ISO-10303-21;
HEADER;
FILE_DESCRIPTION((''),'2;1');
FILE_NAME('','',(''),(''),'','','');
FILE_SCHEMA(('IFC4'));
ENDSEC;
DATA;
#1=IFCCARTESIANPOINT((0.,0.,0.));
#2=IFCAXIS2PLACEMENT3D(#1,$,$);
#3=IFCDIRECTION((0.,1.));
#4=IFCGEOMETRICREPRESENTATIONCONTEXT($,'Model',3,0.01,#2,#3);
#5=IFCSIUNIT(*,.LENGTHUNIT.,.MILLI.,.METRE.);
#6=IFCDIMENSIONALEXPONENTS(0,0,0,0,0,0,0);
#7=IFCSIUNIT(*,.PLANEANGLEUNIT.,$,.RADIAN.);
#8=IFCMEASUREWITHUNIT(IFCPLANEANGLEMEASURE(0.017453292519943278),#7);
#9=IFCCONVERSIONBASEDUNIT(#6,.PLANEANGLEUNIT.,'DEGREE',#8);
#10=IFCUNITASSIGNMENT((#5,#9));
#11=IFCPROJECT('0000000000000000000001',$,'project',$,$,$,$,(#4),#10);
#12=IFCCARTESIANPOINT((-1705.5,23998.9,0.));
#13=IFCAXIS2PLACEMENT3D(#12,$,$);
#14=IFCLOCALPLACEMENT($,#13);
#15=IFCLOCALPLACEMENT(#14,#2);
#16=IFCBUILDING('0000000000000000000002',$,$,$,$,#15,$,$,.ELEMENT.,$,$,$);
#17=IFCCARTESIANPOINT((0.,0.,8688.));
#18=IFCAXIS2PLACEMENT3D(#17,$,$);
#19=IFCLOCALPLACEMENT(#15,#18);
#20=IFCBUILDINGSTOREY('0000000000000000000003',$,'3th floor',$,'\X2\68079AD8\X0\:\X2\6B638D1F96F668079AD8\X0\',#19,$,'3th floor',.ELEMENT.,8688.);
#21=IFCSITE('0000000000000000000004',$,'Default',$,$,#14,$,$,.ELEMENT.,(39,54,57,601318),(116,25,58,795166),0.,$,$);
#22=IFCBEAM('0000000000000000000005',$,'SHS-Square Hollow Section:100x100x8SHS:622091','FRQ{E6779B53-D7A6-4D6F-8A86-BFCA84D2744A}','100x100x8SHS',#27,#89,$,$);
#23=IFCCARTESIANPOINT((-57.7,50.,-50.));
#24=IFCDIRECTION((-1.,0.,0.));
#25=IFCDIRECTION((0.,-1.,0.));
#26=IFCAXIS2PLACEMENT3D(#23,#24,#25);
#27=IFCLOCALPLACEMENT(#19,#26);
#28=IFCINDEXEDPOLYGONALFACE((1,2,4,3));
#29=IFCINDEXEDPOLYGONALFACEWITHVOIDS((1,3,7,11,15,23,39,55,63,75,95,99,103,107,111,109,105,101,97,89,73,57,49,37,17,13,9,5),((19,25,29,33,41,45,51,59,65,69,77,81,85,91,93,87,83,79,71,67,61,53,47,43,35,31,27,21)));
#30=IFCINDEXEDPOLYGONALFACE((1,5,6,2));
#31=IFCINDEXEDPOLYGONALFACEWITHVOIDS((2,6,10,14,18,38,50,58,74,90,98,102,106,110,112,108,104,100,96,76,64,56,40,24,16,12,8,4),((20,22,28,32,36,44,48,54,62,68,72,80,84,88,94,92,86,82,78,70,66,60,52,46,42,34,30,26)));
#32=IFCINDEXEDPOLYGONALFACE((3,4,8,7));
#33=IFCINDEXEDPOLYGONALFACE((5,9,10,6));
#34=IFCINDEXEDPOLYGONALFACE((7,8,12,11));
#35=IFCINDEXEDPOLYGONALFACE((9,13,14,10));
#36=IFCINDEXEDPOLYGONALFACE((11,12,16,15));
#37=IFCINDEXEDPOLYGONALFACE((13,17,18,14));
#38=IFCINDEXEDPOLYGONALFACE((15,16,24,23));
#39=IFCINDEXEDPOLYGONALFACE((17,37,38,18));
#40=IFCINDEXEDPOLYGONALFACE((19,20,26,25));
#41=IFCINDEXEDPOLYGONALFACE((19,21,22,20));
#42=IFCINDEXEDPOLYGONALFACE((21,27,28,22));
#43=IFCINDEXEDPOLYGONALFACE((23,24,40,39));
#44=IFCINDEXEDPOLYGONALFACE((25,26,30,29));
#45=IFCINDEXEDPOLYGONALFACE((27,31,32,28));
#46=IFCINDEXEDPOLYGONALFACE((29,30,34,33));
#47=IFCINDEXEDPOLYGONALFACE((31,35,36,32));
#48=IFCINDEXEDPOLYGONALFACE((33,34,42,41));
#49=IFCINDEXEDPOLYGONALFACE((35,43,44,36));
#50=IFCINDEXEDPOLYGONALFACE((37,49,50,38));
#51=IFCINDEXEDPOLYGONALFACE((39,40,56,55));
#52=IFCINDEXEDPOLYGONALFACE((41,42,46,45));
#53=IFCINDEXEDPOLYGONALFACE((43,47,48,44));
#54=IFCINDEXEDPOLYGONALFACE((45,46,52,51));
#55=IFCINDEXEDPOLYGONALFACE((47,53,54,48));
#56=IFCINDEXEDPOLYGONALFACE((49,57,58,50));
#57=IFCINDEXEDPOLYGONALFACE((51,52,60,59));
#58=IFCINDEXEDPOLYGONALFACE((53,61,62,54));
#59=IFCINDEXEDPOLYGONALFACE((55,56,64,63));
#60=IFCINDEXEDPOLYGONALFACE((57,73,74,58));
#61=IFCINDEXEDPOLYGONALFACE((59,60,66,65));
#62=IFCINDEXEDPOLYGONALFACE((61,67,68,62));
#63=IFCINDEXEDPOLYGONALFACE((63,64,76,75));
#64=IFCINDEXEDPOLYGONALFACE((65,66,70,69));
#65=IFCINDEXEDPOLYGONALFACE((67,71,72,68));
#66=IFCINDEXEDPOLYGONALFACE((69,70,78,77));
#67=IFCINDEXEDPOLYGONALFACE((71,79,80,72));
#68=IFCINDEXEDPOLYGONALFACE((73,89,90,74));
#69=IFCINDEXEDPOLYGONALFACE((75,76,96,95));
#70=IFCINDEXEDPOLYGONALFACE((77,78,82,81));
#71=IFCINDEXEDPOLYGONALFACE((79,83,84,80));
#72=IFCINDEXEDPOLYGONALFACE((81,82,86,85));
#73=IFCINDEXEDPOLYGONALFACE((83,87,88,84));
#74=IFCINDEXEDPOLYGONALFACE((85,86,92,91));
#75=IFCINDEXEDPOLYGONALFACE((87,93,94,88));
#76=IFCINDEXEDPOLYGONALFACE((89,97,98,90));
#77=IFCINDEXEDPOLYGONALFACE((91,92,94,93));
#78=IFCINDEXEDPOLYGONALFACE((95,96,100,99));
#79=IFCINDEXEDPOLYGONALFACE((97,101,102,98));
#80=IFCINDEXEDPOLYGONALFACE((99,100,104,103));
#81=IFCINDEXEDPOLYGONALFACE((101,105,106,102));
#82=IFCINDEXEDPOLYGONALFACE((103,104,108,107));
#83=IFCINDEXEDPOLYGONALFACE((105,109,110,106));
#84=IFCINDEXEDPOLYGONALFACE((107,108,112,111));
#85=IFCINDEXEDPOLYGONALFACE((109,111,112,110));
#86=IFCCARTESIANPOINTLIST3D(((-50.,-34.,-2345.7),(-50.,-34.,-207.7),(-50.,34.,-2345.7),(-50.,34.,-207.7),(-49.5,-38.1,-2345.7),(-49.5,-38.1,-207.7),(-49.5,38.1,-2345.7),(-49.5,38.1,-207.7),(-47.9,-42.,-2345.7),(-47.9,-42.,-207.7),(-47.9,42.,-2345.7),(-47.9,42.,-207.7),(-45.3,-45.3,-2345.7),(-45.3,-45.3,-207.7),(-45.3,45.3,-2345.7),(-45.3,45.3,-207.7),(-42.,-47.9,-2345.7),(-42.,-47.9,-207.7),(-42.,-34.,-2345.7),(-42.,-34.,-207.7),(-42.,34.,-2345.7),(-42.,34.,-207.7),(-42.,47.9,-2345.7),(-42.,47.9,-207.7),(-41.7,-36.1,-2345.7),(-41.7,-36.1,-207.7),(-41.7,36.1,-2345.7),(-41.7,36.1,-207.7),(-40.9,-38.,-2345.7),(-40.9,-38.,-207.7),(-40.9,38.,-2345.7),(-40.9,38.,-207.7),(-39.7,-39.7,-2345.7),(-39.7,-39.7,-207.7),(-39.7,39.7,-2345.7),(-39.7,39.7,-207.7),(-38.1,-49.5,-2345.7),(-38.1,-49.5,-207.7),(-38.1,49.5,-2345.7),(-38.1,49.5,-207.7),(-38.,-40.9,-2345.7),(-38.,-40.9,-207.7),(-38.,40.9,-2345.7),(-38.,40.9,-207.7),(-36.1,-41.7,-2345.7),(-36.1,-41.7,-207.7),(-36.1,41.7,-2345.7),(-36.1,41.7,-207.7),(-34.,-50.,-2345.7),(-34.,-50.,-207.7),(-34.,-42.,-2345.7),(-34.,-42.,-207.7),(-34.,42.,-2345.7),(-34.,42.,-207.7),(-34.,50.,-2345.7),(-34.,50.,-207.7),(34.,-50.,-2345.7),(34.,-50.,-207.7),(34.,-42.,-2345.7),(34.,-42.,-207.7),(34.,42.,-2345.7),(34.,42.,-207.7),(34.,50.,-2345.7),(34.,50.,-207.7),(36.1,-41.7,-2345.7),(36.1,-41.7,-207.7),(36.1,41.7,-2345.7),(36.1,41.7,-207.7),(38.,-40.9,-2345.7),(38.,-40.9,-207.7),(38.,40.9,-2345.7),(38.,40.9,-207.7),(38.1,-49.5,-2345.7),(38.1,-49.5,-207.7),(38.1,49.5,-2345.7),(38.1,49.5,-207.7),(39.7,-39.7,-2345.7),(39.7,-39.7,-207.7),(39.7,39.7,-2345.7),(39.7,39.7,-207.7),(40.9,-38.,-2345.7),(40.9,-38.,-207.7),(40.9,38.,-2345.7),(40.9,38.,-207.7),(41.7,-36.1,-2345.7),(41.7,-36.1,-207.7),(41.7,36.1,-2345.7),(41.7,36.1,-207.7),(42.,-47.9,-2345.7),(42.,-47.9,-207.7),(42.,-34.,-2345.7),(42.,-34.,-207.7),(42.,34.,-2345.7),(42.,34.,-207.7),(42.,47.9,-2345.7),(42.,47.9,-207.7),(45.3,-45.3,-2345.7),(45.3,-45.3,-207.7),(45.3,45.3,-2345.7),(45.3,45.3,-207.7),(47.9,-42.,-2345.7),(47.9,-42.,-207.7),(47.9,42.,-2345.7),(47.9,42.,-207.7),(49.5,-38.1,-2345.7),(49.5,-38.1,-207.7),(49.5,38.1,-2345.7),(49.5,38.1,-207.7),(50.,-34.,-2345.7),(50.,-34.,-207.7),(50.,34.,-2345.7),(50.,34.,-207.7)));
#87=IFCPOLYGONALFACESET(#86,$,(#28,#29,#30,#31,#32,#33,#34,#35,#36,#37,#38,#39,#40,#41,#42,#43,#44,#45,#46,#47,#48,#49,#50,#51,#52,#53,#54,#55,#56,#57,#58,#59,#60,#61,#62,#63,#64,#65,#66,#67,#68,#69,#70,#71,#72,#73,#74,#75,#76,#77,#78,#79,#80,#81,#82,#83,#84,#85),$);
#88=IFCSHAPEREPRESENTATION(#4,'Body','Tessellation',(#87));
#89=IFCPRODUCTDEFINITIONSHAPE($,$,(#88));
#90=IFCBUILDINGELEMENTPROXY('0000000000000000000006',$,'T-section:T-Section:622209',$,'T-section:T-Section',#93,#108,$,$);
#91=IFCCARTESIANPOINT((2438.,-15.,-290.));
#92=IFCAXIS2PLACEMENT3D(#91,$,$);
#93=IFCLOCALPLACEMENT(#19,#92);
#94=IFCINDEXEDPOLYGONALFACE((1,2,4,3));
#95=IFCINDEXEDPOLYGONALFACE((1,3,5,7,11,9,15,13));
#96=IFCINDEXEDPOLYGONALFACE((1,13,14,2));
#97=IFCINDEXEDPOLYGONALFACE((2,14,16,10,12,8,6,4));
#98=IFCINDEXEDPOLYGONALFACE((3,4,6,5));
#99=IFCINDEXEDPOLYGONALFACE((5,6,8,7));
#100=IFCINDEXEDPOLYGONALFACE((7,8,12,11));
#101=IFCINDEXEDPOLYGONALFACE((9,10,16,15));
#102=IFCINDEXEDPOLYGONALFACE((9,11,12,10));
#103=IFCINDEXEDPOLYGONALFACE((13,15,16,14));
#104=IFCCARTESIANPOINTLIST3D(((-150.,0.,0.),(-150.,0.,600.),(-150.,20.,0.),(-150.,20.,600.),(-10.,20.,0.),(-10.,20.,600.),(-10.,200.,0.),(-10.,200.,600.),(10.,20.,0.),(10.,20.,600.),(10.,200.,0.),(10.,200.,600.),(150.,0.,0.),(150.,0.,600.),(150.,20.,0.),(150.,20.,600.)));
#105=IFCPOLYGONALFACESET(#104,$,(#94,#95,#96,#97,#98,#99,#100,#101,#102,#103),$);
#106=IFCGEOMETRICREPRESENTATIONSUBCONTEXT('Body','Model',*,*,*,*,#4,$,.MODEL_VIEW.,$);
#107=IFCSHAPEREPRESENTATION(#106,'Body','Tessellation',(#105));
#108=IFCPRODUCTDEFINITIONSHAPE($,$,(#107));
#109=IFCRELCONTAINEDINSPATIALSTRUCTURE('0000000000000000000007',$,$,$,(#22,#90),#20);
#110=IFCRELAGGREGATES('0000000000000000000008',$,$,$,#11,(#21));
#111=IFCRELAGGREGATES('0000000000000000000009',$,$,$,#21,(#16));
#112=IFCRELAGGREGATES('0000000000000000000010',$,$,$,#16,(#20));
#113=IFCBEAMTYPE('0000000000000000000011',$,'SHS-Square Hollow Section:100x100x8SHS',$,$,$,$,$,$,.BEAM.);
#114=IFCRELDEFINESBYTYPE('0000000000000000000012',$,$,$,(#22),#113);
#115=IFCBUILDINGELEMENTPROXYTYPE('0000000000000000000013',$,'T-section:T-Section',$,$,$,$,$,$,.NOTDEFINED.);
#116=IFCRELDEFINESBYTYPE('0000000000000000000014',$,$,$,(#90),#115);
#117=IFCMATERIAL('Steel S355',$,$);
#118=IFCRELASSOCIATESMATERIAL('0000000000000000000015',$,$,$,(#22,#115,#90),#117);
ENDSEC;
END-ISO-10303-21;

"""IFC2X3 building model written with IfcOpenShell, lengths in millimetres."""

from ifc_helpers import new_model, entity, si_unit, converted_unit, direction, frame, origin, origin_2d, place, context, subcontext, project, spatial, polyline, hollow_rectangle, outline, extrude, clip, halfspace, source, transform, mapped, material, type_object, type_shapes, element, save


model = new_model("IFC2X3")

# Units and contexts
model_context = context("Model", 3, precision=0.01, world=origin(), true_north=direction((0.0, 1.0)))
body_context = subcontext(model_context, "Body", "Model", "MODEL_VIEW")
ifc_project = project(units=[si_unit("LENGTHUNIT", "METRE", prefix="MILLI"), converted_unit("PLANEANGLEUNIT", "DEGREE", entity("IfcPlaneAngleMeasure", 0.017453292519943278), si_unit("PLANEANGLEUNIT", "RADIAN"), dimensions=[0, 0, 0, 0, 0, 0, 0])], contexts=[model_context])

# Site, building, storey
site_placement = place(None, frame((-1705.5, 23998.9, 0.0)))
site = spatial("IfcSite", under=ifc_project, at=site_placement, Name="Default", CompositionType="ELEMENT", RefLatitude=(39, 54, 57, 601318), RefLongitude=(116, 25, 58, 795166), RefElevation=0.0)
building_placement = place(site_placement, origin())
building = spatial("IfcBuilding", under=site, at=building_placement, CompositionType="ELEMENT")
storey_placement = place(building_placement, frame((0.0, 0.0, 8688.0)))
storey = spatial("IfcBuildingStorey", under=building, at=storey_placement, Name="3th floor", ObjectType="标高:正负零标高", LongName="3th floor", CompositionType="ELEMENT", Elevation=8688.0)

# Shared definitions
ifc_material_1 = material(Name="Steel S355")

# Beam
beam_type_1 = type_object("IfcBeamType", Name="SHS-Square Hollow Section:100x100x8SHS", PredefinedType="BEAM")
beam_1_placement = place(storey_placement, frame((-57.7, 50.0, -50.0), z_axis=(-1.0, 0.0, 0.0), x_axis=(0.0, -1.0, 0.0)))
element("IfcBeam", 1, at=beam_1_placement, inside=storey, type_object=beam_type_1, material=ifc_material_1, Name="SHS-Square Hollow Section:100x100x8SHS:622091", Description="FRQ{E6779B53-D7A6-4D6F-8A86-BFCA84D2744A}", ObjectType="100x100x8SHS", context=model_context, shape_type="Clipping", body=[
    clip(clip(extrude(hollow_rectangle(XDim=100.0, YDim=100.0, WallThickness=8.0, InnerFilletRadius=8.0, OuterFilletRadius=16.0, at=origin_2d()), origin(), (0.0, 0.0, -1.0), 2551.4), halfspace(frame((50.0, -8638.0, -207.7), z_axis=(0.0, 0.0, -1.0), x_axis=(-1.0, 0.0, 0.0)), True)), halfspace(frame((50.0, -8638.0, -2345.7), z_axis=(0.0, 0.0, 1.0), x_axis=(1.0, 0.0, 0.0)), True)),
])

# Building element proxy
building_element_proxy_type_1 = type_object("IfcBuildingElementProxyType", Name="T-section:T-Section", PredefinedType="NOTDEFINED", material=ifc_material_1)
shared_shape_1 = source(origin(), body_context, "Body", "SweptSolid", [
    extrude(outline(polyline([(-140.0, 10.0), (-140.0, -10.0), (40.0, -10.0), (40.0, -150.0), (60.0, -150.0), (60.0, 150.0), (40.0, 150.0), (40.0, 10.0), (-140.0, 10.0)])), frame((0.0, 60.0, 0.0), z_axis=(0.0, 0.0, -1.0), x_axis=(0.0, -1.0, 0.0)), (0.0, 0.0, -1.0), 600.0),
])
type_shapes(building_element_proxy_type_1, [shared_shape_1])
proxy_placement = place(storey_placement, frame((2438.0, -15.0, -290.0)))
element("IfcBuildingElementProxy", 2, at=proxy_placement, inside=storey, type_object=building_element_proxy_type_1, material=ifc_material_1, Name="T-section:T-Section:622209", ObjectType="T-section:T-Section", context=body_context, shape_type="MappedRepresentation", body=[
    mapped(shared_shape_1, transform((0.0, 0.0, 0.0), scale=1.0)),
])

save(model, "model.ifc")
